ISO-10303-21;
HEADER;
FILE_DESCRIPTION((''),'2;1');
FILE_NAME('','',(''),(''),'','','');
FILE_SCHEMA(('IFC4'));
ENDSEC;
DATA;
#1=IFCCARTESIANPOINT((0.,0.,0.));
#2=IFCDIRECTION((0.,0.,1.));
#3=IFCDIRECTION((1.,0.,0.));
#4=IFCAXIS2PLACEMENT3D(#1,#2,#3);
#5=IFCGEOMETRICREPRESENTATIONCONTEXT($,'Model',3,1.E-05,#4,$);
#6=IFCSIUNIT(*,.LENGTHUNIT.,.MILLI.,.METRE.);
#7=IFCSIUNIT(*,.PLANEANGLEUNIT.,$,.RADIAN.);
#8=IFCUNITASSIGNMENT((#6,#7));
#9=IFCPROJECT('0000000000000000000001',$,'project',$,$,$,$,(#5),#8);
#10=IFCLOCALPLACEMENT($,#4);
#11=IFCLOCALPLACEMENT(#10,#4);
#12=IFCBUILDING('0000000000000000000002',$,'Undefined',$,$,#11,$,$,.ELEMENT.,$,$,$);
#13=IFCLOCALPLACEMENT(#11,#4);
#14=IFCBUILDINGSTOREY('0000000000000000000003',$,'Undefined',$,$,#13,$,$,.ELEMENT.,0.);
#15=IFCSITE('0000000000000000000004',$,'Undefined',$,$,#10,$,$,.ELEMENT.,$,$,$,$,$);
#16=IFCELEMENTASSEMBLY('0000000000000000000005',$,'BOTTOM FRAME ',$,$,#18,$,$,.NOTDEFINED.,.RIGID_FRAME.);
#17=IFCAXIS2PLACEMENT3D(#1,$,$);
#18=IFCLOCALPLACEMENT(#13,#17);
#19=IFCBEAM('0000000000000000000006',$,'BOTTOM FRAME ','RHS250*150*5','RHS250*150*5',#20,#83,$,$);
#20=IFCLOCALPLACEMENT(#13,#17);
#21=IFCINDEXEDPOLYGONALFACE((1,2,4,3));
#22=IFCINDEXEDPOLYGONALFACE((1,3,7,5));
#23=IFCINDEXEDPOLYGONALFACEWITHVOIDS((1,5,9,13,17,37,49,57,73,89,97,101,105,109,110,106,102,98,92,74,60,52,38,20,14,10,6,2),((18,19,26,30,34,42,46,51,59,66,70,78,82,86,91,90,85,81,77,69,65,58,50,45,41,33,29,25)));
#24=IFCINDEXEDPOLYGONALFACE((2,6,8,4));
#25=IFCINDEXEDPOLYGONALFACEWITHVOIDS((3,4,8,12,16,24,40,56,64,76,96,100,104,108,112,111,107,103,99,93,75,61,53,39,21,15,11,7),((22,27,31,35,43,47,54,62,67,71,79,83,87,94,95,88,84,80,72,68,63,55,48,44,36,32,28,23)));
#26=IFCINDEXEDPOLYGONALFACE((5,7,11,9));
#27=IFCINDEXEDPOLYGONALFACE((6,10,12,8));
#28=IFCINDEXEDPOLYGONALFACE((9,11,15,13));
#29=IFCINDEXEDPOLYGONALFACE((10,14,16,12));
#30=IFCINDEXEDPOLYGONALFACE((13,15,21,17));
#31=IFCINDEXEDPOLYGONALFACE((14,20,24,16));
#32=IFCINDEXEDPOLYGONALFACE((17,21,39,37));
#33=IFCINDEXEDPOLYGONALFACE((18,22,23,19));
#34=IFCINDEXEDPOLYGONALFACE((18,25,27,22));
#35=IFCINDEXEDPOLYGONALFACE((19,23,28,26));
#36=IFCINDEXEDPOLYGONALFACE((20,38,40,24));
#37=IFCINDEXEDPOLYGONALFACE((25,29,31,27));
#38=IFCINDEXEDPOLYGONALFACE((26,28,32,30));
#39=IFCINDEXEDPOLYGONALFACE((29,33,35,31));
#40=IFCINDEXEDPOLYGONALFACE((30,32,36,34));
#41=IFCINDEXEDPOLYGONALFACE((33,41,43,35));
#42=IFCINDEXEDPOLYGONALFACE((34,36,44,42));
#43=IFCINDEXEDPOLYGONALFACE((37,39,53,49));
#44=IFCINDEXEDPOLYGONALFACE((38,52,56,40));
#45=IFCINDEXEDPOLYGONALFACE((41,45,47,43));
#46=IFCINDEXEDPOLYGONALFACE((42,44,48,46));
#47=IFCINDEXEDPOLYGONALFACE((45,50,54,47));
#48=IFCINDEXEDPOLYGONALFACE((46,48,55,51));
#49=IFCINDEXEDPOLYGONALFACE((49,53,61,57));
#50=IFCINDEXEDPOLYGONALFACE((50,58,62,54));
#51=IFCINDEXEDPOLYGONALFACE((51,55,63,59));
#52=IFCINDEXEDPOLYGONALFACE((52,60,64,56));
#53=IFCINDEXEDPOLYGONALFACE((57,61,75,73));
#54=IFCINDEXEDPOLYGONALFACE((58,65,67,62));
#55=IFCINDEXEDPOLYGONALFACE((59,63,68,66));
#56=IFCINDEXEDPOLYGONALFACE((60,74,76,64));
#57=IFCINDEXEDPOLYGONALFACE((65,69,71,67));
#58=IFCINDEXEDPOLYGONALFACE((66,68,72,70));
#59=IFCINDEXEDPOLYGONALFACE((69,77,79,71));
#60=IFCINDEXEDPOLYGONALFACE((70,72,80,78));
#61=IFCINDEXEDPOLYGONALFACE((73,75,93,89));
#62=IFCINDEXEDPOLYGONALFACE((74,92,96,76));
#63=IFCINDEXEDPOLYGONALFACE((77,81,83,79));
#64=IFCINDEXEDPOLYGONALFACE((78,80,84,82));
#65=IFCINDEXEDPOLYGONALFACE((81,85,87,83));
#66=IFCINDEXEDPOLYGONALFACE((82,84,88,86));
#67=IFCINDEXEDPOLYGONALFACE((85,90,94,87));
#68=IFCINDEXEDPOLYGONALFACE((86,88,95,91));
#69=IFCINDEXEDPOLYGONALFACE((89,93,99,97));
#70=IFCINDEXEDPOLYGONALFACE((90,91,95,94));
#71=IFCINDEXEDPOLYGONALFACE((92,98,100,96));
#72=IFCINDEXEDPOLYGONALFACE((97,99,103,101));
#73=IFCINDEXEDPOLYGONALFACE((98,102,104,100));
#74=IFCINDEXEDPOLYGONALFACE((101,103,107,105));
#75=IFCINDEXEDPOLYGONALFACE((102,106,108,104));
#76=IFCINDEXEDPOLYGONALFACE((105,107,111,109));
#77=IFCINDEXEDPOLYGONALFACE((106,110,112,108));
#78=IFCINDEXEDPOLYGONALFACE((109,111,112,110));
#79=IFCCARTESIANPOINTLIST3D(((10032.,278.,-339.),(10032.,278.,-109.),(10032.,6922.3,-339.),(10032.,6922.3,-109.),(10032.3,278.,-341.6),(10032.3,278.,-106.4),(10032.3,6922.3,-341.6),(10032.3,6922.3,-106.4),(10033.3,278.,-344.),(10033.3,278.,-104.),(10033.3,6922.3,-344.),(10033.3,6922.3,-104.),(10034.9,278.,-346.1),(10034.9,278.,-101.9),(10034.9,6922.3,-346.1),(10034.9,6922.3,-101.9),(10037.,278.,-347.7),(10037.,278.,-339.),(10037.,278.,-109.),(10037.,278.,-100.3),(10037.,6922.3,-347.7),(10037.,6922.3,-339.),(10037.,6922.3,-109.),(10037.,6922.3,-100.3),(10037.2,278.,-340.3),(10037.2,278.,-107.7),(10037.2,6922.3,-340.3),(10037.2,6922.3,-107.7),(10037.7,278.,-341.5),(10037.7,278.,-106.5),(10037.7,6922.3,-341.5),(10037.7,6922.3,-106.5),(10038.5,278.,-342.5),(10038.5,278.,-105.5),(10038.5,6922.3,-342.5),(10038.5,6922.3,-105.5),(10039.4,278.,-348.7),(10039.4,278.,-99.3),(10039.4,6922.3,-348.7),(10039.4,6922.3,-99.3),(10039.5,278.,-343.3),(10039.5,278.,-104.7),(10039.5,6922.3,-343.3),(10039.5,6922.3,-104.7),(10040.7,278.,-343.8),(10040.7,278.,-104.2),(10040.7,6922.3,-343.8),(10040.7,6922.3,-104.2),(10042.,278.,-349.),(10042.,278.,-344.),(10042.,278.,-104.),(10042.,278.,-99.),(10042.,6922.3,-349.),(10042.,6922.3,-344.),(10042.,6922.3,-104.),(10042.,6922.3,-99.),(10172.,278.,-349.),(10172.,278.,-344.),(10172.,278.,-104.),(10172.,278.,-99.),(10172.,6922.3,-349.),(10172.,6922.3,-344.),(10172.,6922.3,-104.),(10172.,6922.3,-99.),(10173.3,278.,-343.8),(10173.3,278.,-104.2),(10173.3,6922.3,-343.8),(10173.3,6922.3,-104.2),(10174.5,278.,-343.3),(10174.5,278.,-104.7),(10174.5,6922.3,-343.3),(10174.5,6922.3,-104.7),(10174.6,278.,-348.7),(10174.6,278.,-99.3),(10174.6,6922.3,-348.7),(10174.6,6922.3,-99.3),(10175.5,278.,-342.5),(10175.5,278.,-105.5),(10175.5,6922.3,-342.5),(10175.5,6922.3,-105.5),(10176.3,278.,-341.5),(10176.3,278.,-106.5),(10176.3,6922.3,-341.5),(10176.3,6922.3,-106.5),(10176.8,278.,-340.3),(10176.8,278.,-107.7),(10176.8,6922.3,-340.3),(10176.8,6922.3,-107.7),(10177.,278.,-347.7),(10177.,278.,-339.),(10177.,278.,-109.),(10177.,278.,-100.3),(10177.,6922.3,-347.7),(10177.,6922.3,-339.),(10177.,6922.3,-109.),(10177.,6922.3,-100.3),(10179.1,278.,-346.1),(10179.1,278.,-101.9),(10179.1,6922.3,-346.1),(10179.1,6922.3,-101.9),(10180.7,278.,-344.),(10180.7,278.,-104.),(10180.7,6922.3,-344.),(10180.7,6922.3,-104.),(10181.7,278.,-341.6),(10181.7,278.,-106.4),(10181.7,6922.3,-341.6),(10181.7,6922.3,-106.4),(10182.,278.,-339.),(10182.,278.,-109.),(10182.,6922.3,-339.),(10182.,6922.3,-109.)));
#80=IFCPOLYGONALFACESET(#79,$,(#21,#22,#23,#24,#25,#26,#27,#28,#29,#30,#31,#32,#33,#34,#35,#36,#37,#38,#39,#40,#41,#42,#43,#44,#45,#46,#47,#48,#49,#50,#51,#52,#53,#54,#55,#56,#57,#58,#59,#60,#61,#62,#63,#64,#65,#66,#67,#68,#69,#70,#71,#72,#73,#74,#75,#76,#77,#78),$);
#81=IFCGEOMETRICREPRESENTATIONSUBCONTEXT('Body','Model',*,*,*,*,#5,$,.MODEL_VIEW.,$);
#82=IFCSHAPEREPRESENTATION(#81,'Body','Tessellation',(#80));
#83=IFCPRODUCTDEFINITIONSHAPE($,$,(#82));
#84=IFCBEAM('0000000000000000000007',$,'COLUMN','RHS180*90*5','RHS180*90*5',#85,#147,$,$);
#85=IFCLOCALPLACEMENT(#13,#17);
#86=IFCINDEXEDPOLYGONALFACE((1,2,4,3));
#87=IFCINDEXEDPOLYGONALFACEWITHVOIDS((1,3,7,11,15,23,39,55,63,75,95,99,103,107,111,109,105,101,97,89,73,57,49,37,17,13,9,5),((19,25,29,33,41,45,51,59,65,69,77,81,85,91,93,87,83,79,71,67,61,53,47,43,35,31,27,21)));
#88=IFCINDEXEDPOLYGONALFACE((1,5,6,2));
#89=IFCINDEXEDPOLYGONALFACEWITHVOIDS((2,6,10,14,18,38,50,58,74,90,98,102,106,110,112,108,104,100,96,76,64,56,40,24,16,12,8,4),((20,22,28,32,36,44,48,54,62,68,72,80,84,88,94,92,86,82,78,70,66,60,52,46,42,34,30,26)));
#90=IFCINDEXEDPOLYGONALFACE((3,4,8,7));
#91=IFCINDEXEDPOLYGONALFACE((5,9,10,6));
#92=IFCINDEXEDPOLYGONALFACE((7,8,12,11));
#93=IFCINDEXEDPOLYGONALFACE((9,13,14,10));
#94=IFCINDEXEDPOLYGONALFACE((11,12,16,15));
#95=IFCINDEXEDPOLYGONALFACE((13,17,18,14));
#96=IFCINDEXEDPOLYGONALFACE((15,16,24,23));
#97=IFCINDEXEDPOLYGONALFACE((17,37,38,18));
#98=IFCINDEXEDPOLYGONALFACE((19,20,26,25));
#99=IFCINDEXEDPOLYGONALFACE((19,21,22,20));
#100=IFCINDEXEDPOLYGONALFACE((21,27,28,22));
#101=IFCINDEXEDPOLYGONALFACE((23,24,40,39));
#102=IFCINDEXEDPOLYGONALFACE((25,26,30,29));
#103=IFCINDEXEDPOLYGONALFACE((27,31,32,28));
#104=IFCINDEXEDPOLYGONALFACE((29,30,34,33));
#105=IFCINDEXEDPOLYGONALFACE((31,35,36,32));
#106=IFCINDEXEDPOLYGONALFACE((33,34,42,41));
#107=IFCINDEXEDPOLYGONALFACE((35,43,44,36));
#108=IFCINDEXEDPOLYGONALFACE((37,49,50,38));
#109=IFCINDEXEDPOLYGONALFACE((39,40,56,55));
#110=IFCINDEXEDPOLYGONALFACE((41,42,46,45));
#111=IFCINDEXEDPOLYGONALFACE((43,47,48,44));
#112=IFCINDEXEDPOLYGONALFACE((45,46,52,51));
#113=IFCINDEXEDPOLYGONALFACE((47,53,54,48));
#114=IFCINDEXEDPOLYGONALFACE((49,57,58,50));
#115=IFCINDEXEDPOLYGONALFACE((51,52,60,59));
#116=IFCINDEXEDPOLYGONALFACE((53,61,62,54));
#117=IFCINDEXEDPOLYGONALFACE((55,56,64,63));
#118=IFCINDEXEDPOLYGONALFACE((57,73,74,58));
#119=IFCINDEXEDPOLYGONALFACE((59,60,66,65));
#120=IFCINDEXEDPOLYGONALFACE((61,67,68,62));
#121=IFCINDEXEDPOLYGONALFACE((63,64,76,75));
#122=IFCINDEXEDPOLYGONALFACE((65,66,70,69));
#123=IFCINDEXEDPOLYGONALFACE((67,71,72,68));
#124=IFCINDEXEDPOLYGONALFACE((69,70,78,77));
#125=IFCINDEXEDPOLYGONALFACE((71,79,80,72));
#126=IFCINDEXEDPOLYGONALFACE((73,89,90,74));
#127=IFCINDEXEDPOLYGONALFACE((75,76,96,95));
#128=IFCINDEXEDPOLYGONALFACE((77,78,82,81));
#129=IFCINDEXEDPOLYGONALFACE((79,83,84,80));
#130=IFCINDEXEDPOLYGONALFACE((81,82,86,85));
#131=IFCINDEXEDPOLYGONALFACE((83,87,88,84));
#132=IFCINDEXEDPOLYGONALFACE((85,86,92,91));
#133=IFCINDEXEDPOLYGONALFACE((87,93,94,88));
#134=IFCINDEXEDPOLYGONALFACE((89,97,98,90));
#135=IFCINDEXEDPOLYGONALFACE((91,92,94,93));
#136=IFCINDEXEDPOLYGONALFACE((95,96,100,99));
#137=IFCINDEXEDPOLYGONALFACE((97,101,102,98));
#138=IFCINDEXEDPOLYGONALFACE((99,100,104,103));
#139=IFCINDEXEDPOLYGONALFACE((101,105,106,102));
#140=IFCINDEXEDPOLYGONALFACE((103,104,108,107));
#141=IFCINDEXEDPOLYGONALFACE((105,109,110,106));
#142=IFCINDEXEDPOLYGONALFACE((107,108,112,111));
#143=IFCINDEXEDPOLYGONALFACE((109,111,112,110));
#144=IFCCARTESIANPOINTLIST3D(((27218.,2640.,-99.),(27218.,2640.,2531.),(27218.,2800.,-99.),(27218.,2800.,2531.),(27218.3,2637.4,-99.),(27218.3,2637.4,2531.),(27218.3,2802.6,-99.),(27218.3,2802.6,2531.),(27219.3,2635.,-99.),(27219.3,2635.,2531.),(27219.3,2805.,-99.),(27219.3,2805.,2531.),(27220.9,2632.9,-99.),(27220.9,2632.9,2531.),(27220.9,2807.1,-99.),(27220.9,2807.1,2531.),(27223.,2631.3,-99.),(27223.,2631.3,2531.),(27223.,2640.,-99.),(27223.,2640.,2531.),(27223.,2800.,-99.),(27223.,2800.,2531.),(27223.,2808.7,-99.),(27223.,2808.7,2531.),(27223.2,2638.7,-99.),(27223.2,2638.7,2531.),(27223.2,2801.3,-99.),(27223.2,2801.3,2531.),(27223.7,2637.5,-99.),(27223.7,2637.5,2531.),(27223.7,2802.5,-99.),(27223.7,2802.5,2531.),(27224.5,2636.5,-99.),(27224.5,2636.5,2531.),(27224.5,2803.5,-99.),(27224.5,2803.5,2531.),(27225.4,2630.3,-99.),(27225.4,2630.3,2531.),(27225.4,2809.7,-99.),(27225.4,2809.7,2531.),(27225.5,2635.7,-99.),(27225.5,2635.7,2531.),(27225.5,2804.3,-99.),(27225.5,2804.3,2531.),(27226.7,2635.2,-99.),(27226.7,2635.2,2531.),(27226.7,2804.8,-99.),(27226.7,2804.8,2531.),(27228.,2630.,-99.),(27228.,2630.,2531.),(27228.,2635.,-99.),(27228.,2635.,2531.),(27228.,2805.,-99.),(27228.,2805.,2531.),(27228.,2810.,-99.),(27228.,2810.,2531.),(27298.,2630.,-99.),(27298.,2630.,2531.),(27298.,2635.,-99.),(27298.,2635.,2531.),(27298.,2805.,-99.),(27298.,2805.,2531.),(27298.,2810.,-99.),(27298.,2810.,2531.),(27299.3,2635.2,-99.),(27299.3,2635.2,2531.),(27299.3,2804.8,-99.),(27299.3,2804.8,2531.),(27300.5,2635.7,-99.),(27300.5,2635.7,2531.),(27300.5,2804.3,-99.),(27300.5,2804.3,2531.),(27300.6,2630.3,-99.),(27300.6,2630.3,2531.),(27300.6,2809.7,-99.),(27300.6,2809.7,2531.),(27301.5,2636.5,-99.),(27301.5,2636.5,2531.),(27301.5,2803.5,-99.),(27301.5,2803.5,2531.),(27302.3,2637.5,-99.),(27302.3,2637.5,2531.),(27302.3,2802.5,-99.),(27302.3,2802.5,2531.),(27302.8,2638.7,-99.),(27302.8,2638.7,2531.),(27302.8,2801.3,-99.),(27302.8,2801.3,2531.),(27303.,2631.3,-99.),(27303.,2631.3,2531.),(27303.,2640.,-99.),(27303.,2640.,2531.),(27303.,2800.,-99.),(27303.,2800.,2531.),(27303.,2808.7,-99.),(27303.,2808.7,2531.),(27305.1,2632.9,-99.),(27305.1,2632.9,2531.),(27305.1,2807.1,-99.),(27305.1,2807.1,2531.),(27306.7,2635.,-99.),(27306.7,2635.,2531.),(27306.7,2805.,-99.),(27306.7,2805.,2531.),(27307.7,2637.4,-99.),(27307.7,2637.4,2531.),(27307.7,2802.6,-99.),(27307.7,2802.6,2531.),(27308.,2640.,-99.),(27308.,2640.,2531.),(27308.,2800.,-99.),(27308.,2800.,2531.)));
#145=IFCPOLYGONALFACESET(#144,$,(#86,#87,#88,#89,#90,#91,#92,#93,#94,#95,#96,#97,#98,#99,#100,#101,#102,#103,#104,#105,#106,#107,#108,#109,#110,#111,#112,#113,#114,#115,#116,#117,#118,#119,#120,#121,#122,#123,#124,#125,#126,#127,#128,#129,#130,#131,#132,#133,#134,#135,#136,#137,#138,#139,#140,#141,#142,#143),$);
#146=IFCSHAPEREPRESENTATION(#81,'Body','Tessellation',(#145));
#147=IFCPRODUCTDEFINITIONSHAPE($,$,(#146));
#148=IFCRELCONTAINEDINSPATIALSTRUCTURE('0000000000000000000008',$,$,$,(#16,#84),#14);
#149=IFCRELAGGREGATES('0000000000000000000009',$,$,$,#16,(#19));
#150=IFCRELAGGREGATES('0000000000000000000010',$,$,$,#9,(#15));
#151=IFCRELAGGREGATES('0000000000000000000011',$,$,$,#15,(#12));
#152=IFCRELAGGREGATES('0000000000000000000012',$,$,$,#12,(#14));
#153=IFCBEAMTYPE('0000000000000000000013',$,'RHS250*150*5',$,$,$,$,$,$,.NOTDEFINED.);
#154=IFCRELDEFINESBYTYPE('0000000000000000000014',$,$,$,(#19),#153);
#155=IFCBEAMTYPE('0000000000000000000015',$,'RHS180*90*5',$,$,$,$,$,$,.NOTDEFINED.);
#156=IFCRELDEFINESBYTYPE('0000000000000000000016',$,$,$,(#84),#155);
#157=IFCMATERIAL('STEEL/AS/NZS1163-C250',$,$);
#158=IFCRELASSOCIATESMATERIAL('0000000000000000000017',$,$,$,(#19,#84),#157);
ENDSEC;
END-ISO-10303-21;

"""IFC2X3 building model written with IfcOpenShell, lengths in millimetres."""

from ifc_helpers import new_model, si_unit, frame, origin_with_axes, origin_2d_with_axis, place, context, subcontext, project, spatial, hollow_rectangle, extrude, material, type_object, element, aggregate, save


model = new_model("IFC2X3")

# Units and contexts
model_context = context("Model", 3, precision=1e-05, world=origin_with_axes())
body_context = subcontext(model_context, "Body", "Model", "MODEL_VIEW")
ifc_project = project(units=[si_unit("LENGTHUNIT", "METRE", prefix="MILLI"), si_unit("PLANEANGLEUNIT", "RADIAN")], contexts=[model_context])

# Site, building, storey
site_placement = place(None, origin_with_axes())
site = spatial("IfcSite", under=ifc_project, at=site_placement, Name="Undefined", CompositionType="ELEMENT")
building_placement = place(site_placement, origin_with_axes())
building = spatial("IfcBuilding", under=site, at=building_placement, Name="Undefined", CompositionType="ELEMENT")
storey_placement = place(building_placement, origin_with_axes())
storey = spatial("IfcBuildingStorey", under=building, at=storey_placement, Name="Undefined", CompositionType="ELEMENT", Elevation=0.0)

# Shared definitions
ifc_material_1 = material(Name="STEEL/AS/NZS1163-C250")

# Element assembly, beam
beam_type_1 = type_object("IfcBeamType", Name="RHS250*150*5", PredefinedType="NOTDEFINED")
assembly_1_placement = place(storey_placement, origin_with_axes())
assembly_1 = element("IfcElementAssembly", 1, at=assembly_1_placement, inside=storey, Name="BOTTOM FRAME ", AssemblyPlace="NOTDEFINED", PredefinedType="RIGID_FRAME")
beam_1_placement = place(assembly_1_placement, frame((10107.0, 6922.3, -224.0), z_axis=(0.0, 0.0, 1.0), x_axis=(0.0, -1.0, 0.0)))
beam_1 = element("IfcBeam", 2, at=beam_1_placement, type_object=beam_type_1, material=ifc_material_1, Name="BOTTOM FRAME ", Description="RHS250*150*5", ObjectType="RHS250*150*5", context=body_context, shape_type="SweptSolid", body=[
    extrude(hollow_rectangle(XDim=150.0, YDim=250.0, WallThickness=5.0, InnerFilletRadius=5.0, OuterFilletRadius=10.0, at=origin_2d_with_axis()), frame((6644.3, 0.0, 0.0), z_axis=(-1.0, 0.0, 0.0), x_axis=(0.0, -1.0, 0.0)), (0.0, 0.0, 1.0), 6644.3),
])
aggregate(assembly_1, [beam_1])

# Beam
beam_type_2 = type_object("IfcBeamType", Name="RHS180*90*5", PredefinedType="NOTDEFINED")
beam_2_placement = place(storey_placement, frame((27263.0, 2720.0, 2531.0), z_axis=(0.0, 1.0, 0.0), x_axis=(0.0, 0.0, -1.0)))
element("IfcBeam", 3, at=beam_2_placement, inside=storey, type_object=beam_type_2, material=ifc_material_1, Name="COLUMN", Description="RHS180*90*5", ObjectType="RHS180*90*5", context=body_context, shape_type="SweptSolid", body=[
    extrude(hollow_rectangle(XDim=90.0, YDim=180.0, WallThickness=5.0, InnerFilletRadius=5.0, OuterFilletRadius=10.0, at=origin_2d_with_axis()), frame((2630.0, 0.0, 0.0), z_axis=(-1.0, 0.0, 0.0), x_axis=(0.0, -1.0, 0.0)), (0.0, 0.0, 1.0), 2630.0),
])

save(model, "model.ifc")
